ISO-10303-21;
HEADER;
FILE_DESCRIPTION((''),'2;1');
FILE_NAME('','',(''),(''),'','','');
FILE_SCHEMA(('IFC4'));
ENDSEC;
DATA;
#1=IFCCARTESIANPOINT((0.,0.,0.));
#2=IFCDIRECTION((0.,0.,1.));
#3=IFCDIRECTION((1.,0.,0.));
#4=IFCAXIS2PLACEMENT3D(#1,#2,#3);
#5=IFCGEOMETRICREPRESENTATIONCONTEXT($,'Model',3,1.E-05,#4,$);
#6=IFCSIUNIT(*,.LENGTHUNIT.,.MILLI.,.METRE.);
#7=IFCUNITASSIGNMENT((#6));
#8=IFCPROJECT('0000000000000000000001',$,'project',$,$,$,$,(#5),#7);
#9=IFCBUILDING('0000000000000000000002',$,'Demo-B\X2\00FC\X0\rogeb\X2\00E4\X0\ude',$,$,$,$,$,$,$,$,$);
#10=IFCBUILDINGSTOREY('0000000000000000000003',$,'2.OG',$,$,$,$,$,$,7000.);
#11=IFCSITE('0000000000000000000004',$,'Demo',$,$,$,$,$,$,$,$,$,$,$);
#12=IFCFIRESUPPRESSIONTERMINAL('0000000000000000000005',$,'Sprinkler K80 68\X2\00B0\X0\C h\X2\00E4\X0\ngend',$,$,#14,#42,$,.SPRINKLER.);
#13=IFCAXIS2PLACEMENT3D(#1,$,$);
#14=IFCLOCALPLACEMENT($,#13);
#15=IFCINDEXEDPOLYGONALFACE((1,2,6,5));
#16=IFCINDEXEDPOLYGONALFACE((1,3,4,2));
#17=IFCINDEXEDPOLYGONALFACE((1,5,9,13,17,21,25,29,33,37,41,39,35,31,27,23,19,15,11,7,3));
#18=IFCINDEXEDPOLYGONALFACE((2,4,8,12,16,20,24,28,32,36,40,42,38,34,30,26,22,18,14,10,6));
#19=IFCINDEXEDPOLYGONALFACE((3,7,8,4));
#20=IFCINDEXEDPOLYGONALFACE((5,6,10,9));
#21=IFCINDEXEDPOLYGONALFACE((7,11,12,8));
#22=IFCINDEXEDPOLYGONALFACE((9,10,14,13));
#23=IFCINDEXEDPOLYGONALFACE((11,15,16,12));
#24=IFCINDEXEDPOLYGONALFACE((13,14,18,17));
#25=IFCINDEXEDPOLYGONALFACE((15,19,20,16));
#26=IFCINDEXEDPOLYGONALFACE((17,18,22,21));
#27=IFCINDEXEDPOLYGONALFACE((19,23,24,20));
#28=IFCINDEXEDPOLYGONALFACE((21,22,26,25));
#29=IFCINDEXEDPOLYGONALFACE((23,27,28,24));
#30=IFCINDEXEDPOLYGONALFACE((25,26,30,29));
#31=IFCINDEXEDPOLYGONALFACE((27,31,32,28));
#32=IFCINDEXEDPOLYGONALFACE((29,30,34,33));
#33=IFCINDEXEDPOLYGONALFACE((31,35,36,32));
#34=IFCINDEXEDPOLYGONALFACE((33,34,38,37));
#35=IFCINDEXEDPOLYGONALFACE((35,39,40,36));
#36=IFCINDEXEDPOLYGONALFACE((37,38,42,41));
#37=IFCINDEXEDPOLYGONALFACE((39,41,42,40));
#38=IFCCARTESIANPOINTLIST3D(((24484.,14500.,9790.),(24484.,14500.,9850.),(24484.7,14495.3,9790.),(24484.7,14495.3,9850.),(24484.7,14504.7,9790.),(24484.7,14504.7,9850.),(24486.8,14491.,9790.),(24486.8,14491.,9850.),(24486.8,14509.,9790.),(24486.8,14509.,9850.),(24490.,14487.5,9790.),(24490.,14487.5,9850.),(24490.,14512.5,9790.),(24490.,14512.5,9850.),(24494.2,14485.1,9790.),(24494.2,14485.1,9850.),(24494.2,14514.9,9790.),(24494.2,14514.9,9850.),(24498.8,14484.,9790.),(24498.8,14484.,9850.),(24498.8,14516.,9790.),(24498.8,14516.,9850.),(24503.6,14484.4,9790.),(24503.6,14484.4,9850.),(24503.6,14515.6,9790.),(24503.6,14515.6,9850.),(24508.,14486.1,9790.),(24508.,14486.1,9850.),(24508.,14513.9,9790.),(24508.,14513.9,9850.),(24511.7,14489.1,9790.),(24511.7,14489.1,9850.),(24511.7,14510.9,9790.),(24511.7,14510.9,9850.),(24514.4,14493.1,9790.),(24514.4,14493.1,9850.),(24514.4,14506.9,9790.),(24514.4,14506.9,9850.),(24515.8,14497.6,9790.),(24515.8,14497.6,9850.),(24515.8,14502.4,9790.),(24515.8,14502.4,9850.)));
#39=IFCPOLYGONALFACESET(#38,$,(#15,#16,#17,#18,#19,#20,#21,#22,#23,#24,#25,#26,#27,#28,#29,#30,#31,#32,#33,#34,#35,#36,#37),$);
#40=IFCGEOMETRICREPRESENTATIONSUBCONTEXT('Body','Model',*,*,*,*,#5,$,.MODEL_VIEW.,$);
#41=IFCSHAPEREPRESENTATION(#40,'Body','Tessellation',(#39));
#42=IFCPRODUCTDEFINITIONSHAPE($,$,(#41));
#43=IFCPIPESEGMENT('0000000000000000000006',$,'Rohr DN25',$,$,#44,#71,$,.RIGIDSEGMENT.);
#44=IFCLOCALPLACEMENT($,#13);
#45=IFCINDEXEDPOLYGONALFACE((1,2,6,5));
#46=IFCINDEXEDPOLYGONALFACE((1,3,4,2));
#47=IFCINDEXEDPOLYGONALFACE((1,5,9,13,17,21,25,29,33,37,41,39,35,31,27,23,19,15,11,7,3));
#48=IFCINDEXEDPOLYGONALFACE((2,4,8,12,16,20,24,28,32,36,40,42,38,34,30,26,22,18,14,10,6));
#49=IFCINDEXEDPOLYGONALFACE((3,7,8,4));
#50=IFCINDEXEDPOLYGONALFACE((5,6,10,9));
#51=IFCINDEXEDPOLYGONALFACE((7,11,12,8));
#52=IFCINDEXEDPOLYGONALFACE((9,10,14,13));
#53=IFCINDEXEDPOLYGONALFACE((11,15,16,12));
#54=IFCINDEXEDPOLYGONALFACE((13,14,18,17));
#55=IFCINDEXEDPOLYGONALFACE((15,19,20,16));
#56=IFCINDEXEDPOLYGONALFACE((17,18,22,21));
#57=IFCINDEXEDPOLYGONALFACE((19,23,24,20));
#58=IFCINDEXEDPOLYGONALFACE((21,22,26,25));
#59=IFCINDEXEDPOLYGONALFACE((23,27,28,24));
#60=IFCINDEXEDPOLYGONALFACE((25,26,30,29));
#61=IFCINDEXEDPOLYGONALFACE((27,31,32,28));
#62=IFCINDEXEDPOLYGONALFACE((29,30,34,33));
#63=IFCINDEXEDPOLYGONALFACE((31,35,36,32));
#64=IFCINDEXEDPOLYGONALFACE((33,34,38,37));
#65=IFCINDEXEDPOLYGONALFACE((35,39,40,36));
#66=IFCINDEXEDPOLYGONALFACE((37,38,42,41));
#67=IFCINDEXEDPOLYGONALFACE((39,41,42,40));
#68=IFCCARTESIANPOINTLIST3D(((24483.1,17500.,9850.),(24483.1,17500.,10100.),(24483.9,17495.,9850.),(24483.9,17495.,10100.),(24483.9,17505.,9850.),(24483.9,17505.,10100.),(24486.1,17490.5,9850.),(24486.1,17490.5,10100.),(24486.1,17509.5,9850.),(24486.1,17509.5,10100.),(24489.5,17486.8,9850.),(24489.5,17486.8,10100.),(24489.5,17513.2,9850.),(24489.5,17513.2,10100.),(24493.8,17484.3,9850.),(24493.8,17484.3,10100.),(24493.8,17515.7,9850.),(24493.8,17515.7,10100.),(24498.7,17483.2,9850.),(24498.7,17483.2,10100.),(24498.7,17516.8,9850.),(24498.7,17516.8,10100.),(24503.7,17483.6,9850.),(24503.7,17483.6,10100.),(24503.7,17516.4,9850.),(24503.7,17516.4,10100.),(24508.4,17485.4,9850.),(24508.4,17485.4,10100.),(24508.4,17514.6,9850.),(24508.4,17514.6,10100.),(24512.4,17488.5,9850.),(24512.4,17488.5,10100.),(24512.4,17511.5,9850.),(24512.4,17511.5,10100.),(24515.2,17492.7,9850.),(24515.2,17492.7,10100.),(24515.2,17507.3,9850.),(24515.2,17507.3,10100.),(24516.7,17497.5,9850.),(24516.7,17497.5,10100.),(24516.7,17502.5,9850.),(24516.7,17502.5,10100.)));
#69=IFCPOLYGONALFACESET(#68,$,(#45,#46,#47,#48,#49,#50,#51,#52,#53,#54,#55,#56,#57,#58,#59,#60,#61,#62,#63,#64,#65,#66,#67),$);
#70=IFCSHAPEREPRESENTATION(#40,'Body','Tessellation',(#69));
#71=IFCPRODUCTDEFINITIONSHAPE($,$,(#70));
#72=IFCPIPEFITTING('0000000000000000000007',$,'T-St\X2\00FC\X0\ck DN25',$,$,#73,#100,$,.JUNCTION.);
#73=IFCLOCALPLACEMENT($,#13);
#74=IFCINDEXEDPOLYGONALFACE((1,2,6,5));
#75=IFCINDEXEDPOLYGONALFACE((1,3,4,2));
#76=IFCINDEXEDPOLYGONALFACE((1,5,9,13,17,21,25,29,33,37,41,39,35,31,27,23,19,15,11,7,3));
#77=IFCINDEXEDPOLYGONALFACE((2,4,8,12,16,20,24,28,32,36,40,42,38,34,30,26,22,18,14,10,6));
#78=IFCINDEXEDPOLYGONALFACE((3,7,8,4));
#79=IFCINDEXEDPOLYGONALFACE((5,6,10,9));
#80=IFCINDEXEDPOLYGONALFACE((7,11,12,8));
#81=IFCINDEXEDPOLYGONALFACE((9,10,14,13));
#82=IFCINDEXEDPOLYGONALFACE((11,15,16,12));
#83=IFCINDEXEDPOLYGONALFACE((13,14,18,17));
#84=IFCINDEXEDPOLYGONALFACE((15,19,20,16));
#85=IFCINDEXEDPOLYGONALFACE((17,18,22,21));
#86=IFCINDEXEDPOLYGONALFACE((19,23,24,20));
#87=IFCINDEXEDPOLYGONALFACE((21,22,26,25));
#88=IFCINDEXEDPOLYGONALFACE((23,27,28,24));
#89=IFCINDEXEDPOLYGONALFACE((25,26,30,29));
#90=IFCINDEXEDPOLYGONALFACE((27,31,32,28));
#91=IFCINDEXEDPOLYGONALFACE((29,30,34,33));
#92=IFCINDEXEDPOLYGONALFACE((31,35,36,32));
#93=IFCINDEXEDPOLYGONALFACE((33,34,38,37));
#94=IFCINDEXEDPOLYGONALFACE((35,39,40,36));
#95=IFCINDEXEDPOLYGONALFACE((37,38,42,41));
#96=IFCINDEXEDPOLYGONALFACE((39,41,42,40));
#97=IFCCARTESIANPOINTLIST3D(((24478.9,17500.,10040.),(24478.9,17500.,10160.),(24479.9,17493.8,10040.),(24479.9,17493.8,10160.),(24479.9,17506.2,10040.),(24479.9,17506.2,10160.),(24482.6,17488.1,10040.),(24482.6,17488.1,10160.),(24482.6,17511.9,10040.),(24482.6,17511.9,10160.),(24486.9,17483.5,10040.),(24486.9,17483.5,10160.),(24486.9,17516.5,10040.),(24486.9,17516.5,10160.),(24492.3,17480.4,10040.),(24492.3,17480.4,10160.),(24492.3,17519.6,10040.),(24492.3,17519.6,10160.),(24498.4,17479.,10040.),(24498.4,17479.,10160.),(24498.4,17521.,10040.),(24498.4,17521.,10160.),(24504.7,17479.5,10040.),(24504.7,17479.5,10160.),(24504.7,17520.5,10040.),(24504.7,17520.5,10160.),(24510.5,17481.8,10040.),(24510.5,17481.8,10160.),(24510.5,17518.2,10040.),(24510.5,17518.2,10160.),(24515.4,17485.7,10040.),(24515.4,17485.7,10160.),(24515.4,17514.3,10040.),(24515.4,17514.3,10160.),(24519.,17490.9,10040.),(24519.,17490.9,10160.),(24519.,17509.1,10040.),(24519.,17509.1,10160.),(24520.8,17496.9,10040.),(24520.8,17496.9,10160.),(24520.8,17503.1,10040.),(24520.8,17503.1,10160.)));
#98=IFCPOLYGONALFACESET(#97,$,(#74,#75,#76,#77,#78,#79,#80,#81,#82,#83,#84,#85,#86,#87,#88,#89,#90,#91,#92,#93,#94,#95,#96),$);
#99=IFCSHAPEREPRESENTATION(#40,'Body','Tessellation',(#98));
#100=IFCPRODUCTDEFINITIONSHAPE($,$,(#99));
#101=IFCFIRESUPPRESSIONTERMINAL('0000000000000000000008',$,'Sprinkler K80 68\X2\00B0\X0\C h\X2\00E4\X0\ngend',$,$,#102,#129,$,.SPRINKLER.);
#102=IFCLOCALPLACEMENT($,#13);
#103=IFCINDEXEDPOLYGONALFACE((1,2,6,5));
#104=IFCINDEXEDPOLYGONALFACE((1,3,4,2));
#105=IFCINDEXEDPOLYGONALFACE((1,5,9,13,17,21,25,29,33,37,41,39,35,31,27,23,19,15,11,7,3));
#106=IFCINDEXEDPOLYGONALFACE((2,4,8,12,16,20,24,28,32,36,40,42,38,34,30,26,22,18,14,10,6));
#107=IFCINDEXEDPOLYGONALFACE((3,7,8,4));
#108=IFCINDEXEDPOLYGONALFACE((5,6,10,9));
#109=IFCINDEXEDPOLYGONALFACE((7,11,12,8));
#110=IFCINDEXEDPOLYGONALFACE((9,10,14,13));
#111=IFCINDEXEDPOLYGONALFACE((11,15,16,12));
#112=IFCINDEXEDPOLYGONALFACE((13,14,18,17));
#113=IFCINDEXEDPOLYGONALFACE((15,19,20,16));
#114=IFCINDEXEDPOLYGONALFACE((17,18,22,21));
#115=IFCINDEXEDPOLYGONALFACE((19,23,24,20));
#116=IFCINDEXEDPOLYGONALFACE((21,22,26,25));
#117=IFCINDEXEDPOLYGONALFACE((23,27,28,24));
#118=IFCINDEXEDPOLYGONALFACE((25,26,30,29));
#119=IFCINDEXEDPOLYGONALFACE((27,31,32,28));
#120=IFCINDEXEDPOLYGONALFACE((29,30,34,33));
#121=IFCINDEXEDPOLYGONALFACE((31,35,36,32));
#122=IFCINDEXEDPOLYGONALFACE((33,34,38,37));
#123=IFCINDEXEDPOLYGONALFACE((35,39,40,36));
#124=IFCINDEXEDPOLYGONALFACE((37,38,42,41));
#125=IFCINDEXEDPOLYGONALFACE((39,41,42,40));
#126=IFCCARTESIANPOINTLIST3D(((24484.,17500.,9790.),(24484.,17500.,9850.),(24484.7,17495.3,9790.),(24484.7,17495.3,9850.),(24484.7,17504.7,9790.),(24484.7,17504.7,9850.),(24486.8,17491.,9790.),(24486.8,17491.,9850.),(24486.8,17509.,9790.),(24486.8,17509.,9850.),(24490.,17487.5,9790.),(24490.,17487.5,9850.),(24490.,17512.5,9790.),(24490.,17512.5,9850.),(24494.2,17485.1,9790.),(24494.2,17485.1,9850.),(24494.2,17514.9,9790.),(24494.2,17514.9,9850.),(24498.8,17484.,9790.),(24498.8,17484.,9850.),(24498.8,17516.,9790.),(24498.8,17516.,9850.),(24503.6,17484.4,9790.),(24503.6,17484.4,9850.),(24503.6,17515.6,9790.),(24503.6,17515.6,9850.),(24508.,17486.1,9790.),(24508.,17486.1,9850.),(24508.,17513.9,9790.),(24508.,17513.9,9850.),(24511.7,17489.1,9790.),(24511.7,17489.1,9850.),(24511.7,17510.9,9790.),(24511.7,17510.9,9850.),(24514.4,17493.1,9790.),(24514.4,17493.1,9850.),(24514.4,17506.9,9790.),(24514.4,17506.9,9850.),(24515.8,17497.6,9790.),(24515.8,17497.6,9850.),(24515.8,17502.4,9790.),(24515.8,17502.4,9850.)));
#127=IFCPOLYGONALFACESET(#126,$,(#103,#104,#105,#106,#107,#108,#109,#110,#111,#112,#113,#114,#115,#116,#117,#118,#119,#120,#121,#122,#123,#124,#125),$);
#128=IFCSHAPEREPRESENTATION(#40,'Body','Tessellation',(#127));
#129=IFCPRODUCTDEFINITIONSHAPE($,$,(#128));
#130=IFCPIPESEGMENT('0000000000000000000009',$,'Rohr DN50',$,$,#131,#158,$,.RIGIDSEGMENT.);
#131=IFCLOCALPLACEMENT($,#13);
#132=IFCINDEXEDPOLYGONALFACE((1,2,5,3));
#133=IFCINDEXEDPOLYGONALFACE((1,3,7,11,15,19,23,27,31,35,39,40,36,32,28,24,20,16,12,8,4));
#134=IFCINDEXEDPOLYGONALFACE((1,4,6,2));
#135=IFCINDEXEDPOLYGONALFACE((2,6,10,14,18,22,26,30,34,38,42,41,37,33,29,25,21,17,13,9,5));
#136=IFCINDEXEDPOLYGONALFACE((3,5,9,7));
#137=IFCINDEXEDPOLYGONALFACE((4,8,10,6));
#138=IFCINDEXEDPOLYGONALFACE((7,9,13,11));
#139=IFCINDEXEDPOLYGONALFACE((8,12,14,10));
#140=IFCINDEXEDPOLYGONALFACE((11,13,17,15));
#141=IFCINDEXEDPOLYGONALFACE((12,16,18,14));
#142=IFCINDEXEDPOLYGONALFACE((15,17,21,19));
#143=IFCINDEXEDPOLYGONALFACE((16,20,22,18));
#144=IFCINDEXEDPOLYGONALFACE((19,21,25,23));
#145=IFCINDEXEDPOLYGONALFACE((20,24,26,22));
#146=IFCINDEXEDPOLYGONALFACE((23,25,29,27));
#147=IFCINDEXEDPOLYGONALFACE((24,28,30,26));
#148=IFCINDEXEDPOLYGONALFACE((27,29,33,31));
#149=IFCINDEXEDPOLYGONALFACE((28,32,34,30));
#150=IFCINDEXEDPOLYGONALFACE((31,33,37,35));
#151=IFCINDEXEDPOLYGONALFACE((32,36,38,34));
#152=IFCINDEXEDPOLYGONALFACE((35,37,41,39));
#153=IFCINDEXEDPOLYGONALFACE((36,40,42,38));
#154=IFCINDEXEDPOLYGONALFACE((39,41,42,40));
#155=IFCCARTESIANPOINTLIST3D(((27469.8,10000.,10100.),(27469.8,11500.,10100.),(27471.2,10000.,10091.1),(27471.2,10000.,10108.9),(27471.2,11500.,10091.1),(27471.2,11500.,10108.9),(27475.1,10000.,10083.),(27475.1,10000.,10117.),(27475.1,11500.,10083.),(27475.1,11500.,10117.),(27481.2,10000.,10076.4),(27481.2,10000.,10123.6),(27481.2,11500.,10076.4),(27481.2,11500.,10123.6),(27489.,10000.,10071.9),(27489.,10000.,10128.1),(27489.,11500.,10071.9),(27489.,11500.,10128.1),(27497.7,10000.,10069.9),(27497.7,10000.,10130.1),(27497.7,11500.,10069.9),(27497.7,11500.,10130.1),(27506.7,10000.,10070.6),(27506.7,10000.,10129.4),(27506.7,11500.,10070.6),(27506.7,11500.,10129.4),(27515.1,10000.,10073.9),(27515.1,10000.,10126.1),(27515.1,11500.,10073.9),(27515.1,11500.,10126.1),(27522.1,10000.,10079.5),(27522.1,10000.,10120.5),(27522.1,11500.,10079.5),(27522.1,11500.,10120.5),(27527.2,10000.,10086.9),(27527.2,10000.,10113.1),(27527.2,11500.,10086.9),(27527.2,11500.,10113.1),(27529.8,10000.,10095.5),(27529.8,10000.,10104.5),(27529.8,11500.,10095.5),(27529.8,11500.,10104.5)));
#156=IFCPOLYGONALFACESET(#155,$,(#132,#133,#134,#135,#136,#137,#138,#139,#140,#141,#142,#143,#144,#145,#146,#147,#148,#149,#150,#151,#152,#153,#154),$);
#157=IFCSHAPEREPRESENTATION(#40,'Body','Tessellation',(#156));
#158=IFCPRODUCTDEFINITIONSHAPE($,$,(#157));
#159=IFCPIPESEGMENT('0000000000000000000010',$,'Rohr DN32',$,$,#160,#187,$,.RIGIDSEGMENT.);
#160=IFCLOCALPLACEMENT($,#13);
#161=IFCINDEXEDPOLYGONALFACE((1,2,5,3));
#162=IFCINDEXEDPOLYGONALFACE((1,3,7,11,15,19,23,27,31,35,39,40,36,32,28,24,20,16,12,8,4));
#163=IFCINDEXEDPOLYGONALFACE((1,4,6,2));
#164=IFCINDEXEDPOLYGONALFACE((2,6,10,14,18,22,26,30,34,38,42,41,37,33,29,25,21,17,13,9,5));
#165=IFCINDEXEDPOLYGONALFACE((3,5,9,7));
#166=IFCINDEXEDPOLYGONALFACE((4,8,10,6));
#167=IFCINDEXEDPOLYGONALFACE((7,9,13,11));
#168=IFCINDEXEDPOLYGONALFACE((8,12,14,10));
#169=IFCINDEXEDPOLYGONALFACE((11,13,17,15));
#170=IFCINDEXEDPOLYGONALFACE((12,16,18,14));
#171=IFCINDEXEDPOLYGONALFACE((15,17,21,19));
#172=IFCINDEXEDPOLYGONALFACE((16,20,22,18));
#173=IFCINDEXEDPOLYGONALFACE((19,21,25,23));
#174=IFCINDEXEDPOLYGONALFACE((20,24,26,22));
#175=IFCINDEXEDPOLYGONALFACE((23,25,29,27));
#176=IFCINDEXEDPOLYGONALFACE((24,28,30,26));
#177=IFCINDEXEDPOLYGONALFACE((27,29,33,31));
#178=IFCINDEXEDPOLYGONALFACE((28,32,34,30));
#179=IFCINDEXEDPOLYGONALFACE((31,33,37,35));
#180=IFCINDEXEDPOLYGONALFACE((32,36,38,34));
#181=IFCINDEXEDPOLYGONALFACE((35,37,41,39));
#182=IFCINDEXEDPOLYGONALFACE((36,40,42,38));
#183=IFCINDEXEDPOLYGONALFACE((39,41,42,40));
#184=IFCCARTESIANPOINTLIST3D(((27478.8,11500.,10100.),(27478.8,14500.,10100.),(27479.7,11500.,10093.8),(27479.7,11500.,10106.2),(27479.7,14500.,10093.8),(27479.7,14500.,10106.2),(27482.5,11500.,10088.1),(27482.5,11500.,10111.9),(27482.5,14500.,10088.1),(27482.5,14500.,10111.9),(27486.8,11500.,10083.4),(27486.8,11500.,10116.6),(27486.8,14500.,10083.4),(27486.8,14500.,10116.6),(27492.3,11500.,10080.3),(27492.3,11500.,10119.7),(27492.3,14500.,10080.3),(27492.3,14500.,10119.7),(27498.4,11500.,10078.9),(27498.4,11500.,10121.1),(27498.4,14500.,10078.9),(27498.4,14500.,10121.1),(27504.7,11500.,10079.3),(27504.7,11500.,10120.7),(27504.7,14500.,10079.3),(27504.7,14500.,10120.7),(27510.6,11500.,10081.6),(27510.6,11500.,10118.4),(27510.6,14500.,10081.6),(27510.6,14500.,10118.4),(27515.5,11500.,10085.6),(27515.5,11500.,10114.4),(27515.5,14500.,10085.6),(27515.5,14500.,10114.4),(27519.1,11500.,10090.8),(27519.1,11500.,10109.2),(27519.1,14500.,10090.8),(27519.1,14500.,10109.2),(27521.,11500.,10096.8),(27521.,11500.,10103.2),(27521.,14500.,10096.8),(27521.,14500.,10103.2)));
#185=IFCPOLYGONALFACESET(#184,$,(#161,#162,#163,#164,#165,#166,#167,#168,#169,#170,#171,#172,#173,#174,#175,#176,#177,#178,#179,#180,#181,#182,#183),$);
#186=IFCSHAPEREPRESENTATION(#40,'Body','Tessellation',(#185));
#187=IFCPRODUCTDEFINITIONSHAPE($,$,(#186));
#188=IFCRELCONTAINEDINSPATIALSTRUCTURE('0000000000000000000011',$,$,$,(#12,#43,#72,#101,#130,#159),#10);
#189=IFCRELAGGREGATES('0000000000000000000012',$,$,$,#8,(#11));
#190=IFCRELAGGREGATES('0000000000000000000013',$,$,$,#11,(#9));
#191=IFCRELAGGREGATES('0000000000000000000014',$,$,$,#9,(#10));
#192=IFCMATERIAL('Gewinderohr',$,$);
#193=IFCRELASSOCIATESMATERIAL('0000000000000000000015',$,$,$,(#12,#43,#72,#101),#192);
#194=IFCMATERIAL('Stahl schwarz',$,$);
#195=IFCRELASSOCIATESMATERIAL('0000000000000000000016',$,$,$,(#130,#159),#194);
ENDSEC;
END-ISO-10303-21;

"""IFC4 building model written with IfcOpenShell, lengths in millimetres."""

from ifc_helpers import new_model, si_unit, frame, origin_with_axes, place, context, subcontext, project, spatial, circle, extrude, material, element, save


model = new_model("IFC4")

# Units and contexts
model_context = context("Model", 3, precision=1e-05, world=origin_with_axes())
body_context = subcontext(model_context, "Body", "Model", "MODEL_VIEW")
ifc_project = project(units=[si_unit("LENGTHUNIT", "METRE", prefix="MILLI")], contexts=[model_context])

# Site, building, storey
site = spatial("IfcSite", under=ifc_project, Name="Demo")
building = spatial("IfcBuilding", under=site, Name="Demo-Bürogebäude")
storey = spatial("IfcBuildingStorey", under=building, Name="2.OG", Elevation=7000.0)

# Fire suppression terminal
ifc_material_1 = material(Name="Gewinderohr")
fire_suppression_terminal_1_placement = place(None, frame((24500.0, 14500.0, 9850.0), z_axis=(0.0, 0.0, -1.0), x_axis=(-1.0, 0.0, 0.0)))
element("IfcFireSuppressionTerminal", 1, at=fire_suppression_terminal_1_placement, inside=storey, material=ifc_material_1, Name="Sprinkler K80 68°C hängend", PredefinedType="SPRINKLER", context=body_context, shape_type="SweptSolid", body=[
    extrude(circle(Radius=16.0), origin_with_axes(), (0.0, 0.0, 1.0), 60.0),
])

# Pipe segment
pipe_segment_1_placement = place(None, frame((24500.0, 17500.0, 10100.0), z_axis=(0.0, 0.0, -1.0), x_axis=(-1.0, 0.0, 0.0)))
element("IfcPipeSegment", 2, at=pipe_segment_1_placement, inside=storey, material=ifc_material_1, Name="Rohr DN25", PredefinedType="RIGIDSEGMENT", context=body_context, shape_type="SweptSolid", body=[
    extrude(circle(Radius=16.9), origin_with_axes(), (0.0, 0.0, 1.0), 250.0),
])

# Pipe fitting
pipe_fitting_1_placement = place(None, frame((24500.0, 17500.0, 10160.0), z_axis=(0.0, 0.0, -1.0), x_axis=(-1.0, 0.0, 0.0)))
element("IfcPipeFitting", 3, at=pipe_fitting_1_placement, inside=storey, material=ifc_material_1, Name="T-Stück DN25", PredefinedType="JUNCTION", context=body_context, shape_type="SweptSolid", body=[
    extrude(circle(Radius=21.1), origin_with_axes(), (0.0, 0.0, 1.0), 120.0),
])

# Fire suppression terminal
fire_suppression_terminal_2_placement = place(None, frame((24500.0, 17500.0, 9850.0), z_axis=(0.0, 0.0, -1.0), x_axis=(-1.0, 0.0, 0.0)))
element("IfcFireSuppressionTerminal", 4, at=fire_suppression_terminal_2_placement, inside=storey, material=ifc_material_1, Name="Sprinkler K80 68°C hängend", PredefinedType="SPRINKLER", context=body_context, shape_type="SweptSolid", body=[
    extrude(circle(Radius=16.0), origin_with_axes(), (0.0, 0.0, 1.0), 60.0),
])

# Pipe segments
ifc_material_2 = material(Name="Stahl schwarz")
pipe_segment_2_placement = place(None, frame((27500.0, 10000.0, 10100.0), z_axis=(0.0, 1.0, 0.0), x_axis=(-1.0, 0.0, 0.0)))
element("IfcPipeSegment", 5, at=pipe_segment_2_placement, inside=storey, material=ifc_material_2, Name="Rohr DN50", PredefinedType="RIGIDSEGMENT", context=body_context, shape_type="SweptSolid", body=[
    extrude(circle(Radius=30.1), origin_with_axes(), (0.0, 0.0, 1.0), 1500.0),
])
pipe_segment_3_placement = place(None, frame((27500.0, 11500.0, 10100.0), z_axis=(0.0, 1.0, 0.0), x_axis=(-1.0, 0.0, 0.0)))
element("IfcPipeSegment", 6, at=pipe_segment_3_placement, inside=storey, material=ifc_material_2, Name="Rohr DN32", PredefinedType="RIGIDSEGMENT", context=body_context, shape_type="SweptSolid", body=[
    extrude(circle(Radius=21.2), origin_with_axes(), (0.0, 0.0, 1.0), 3000.0),
])

save(model, "model.ifc")
